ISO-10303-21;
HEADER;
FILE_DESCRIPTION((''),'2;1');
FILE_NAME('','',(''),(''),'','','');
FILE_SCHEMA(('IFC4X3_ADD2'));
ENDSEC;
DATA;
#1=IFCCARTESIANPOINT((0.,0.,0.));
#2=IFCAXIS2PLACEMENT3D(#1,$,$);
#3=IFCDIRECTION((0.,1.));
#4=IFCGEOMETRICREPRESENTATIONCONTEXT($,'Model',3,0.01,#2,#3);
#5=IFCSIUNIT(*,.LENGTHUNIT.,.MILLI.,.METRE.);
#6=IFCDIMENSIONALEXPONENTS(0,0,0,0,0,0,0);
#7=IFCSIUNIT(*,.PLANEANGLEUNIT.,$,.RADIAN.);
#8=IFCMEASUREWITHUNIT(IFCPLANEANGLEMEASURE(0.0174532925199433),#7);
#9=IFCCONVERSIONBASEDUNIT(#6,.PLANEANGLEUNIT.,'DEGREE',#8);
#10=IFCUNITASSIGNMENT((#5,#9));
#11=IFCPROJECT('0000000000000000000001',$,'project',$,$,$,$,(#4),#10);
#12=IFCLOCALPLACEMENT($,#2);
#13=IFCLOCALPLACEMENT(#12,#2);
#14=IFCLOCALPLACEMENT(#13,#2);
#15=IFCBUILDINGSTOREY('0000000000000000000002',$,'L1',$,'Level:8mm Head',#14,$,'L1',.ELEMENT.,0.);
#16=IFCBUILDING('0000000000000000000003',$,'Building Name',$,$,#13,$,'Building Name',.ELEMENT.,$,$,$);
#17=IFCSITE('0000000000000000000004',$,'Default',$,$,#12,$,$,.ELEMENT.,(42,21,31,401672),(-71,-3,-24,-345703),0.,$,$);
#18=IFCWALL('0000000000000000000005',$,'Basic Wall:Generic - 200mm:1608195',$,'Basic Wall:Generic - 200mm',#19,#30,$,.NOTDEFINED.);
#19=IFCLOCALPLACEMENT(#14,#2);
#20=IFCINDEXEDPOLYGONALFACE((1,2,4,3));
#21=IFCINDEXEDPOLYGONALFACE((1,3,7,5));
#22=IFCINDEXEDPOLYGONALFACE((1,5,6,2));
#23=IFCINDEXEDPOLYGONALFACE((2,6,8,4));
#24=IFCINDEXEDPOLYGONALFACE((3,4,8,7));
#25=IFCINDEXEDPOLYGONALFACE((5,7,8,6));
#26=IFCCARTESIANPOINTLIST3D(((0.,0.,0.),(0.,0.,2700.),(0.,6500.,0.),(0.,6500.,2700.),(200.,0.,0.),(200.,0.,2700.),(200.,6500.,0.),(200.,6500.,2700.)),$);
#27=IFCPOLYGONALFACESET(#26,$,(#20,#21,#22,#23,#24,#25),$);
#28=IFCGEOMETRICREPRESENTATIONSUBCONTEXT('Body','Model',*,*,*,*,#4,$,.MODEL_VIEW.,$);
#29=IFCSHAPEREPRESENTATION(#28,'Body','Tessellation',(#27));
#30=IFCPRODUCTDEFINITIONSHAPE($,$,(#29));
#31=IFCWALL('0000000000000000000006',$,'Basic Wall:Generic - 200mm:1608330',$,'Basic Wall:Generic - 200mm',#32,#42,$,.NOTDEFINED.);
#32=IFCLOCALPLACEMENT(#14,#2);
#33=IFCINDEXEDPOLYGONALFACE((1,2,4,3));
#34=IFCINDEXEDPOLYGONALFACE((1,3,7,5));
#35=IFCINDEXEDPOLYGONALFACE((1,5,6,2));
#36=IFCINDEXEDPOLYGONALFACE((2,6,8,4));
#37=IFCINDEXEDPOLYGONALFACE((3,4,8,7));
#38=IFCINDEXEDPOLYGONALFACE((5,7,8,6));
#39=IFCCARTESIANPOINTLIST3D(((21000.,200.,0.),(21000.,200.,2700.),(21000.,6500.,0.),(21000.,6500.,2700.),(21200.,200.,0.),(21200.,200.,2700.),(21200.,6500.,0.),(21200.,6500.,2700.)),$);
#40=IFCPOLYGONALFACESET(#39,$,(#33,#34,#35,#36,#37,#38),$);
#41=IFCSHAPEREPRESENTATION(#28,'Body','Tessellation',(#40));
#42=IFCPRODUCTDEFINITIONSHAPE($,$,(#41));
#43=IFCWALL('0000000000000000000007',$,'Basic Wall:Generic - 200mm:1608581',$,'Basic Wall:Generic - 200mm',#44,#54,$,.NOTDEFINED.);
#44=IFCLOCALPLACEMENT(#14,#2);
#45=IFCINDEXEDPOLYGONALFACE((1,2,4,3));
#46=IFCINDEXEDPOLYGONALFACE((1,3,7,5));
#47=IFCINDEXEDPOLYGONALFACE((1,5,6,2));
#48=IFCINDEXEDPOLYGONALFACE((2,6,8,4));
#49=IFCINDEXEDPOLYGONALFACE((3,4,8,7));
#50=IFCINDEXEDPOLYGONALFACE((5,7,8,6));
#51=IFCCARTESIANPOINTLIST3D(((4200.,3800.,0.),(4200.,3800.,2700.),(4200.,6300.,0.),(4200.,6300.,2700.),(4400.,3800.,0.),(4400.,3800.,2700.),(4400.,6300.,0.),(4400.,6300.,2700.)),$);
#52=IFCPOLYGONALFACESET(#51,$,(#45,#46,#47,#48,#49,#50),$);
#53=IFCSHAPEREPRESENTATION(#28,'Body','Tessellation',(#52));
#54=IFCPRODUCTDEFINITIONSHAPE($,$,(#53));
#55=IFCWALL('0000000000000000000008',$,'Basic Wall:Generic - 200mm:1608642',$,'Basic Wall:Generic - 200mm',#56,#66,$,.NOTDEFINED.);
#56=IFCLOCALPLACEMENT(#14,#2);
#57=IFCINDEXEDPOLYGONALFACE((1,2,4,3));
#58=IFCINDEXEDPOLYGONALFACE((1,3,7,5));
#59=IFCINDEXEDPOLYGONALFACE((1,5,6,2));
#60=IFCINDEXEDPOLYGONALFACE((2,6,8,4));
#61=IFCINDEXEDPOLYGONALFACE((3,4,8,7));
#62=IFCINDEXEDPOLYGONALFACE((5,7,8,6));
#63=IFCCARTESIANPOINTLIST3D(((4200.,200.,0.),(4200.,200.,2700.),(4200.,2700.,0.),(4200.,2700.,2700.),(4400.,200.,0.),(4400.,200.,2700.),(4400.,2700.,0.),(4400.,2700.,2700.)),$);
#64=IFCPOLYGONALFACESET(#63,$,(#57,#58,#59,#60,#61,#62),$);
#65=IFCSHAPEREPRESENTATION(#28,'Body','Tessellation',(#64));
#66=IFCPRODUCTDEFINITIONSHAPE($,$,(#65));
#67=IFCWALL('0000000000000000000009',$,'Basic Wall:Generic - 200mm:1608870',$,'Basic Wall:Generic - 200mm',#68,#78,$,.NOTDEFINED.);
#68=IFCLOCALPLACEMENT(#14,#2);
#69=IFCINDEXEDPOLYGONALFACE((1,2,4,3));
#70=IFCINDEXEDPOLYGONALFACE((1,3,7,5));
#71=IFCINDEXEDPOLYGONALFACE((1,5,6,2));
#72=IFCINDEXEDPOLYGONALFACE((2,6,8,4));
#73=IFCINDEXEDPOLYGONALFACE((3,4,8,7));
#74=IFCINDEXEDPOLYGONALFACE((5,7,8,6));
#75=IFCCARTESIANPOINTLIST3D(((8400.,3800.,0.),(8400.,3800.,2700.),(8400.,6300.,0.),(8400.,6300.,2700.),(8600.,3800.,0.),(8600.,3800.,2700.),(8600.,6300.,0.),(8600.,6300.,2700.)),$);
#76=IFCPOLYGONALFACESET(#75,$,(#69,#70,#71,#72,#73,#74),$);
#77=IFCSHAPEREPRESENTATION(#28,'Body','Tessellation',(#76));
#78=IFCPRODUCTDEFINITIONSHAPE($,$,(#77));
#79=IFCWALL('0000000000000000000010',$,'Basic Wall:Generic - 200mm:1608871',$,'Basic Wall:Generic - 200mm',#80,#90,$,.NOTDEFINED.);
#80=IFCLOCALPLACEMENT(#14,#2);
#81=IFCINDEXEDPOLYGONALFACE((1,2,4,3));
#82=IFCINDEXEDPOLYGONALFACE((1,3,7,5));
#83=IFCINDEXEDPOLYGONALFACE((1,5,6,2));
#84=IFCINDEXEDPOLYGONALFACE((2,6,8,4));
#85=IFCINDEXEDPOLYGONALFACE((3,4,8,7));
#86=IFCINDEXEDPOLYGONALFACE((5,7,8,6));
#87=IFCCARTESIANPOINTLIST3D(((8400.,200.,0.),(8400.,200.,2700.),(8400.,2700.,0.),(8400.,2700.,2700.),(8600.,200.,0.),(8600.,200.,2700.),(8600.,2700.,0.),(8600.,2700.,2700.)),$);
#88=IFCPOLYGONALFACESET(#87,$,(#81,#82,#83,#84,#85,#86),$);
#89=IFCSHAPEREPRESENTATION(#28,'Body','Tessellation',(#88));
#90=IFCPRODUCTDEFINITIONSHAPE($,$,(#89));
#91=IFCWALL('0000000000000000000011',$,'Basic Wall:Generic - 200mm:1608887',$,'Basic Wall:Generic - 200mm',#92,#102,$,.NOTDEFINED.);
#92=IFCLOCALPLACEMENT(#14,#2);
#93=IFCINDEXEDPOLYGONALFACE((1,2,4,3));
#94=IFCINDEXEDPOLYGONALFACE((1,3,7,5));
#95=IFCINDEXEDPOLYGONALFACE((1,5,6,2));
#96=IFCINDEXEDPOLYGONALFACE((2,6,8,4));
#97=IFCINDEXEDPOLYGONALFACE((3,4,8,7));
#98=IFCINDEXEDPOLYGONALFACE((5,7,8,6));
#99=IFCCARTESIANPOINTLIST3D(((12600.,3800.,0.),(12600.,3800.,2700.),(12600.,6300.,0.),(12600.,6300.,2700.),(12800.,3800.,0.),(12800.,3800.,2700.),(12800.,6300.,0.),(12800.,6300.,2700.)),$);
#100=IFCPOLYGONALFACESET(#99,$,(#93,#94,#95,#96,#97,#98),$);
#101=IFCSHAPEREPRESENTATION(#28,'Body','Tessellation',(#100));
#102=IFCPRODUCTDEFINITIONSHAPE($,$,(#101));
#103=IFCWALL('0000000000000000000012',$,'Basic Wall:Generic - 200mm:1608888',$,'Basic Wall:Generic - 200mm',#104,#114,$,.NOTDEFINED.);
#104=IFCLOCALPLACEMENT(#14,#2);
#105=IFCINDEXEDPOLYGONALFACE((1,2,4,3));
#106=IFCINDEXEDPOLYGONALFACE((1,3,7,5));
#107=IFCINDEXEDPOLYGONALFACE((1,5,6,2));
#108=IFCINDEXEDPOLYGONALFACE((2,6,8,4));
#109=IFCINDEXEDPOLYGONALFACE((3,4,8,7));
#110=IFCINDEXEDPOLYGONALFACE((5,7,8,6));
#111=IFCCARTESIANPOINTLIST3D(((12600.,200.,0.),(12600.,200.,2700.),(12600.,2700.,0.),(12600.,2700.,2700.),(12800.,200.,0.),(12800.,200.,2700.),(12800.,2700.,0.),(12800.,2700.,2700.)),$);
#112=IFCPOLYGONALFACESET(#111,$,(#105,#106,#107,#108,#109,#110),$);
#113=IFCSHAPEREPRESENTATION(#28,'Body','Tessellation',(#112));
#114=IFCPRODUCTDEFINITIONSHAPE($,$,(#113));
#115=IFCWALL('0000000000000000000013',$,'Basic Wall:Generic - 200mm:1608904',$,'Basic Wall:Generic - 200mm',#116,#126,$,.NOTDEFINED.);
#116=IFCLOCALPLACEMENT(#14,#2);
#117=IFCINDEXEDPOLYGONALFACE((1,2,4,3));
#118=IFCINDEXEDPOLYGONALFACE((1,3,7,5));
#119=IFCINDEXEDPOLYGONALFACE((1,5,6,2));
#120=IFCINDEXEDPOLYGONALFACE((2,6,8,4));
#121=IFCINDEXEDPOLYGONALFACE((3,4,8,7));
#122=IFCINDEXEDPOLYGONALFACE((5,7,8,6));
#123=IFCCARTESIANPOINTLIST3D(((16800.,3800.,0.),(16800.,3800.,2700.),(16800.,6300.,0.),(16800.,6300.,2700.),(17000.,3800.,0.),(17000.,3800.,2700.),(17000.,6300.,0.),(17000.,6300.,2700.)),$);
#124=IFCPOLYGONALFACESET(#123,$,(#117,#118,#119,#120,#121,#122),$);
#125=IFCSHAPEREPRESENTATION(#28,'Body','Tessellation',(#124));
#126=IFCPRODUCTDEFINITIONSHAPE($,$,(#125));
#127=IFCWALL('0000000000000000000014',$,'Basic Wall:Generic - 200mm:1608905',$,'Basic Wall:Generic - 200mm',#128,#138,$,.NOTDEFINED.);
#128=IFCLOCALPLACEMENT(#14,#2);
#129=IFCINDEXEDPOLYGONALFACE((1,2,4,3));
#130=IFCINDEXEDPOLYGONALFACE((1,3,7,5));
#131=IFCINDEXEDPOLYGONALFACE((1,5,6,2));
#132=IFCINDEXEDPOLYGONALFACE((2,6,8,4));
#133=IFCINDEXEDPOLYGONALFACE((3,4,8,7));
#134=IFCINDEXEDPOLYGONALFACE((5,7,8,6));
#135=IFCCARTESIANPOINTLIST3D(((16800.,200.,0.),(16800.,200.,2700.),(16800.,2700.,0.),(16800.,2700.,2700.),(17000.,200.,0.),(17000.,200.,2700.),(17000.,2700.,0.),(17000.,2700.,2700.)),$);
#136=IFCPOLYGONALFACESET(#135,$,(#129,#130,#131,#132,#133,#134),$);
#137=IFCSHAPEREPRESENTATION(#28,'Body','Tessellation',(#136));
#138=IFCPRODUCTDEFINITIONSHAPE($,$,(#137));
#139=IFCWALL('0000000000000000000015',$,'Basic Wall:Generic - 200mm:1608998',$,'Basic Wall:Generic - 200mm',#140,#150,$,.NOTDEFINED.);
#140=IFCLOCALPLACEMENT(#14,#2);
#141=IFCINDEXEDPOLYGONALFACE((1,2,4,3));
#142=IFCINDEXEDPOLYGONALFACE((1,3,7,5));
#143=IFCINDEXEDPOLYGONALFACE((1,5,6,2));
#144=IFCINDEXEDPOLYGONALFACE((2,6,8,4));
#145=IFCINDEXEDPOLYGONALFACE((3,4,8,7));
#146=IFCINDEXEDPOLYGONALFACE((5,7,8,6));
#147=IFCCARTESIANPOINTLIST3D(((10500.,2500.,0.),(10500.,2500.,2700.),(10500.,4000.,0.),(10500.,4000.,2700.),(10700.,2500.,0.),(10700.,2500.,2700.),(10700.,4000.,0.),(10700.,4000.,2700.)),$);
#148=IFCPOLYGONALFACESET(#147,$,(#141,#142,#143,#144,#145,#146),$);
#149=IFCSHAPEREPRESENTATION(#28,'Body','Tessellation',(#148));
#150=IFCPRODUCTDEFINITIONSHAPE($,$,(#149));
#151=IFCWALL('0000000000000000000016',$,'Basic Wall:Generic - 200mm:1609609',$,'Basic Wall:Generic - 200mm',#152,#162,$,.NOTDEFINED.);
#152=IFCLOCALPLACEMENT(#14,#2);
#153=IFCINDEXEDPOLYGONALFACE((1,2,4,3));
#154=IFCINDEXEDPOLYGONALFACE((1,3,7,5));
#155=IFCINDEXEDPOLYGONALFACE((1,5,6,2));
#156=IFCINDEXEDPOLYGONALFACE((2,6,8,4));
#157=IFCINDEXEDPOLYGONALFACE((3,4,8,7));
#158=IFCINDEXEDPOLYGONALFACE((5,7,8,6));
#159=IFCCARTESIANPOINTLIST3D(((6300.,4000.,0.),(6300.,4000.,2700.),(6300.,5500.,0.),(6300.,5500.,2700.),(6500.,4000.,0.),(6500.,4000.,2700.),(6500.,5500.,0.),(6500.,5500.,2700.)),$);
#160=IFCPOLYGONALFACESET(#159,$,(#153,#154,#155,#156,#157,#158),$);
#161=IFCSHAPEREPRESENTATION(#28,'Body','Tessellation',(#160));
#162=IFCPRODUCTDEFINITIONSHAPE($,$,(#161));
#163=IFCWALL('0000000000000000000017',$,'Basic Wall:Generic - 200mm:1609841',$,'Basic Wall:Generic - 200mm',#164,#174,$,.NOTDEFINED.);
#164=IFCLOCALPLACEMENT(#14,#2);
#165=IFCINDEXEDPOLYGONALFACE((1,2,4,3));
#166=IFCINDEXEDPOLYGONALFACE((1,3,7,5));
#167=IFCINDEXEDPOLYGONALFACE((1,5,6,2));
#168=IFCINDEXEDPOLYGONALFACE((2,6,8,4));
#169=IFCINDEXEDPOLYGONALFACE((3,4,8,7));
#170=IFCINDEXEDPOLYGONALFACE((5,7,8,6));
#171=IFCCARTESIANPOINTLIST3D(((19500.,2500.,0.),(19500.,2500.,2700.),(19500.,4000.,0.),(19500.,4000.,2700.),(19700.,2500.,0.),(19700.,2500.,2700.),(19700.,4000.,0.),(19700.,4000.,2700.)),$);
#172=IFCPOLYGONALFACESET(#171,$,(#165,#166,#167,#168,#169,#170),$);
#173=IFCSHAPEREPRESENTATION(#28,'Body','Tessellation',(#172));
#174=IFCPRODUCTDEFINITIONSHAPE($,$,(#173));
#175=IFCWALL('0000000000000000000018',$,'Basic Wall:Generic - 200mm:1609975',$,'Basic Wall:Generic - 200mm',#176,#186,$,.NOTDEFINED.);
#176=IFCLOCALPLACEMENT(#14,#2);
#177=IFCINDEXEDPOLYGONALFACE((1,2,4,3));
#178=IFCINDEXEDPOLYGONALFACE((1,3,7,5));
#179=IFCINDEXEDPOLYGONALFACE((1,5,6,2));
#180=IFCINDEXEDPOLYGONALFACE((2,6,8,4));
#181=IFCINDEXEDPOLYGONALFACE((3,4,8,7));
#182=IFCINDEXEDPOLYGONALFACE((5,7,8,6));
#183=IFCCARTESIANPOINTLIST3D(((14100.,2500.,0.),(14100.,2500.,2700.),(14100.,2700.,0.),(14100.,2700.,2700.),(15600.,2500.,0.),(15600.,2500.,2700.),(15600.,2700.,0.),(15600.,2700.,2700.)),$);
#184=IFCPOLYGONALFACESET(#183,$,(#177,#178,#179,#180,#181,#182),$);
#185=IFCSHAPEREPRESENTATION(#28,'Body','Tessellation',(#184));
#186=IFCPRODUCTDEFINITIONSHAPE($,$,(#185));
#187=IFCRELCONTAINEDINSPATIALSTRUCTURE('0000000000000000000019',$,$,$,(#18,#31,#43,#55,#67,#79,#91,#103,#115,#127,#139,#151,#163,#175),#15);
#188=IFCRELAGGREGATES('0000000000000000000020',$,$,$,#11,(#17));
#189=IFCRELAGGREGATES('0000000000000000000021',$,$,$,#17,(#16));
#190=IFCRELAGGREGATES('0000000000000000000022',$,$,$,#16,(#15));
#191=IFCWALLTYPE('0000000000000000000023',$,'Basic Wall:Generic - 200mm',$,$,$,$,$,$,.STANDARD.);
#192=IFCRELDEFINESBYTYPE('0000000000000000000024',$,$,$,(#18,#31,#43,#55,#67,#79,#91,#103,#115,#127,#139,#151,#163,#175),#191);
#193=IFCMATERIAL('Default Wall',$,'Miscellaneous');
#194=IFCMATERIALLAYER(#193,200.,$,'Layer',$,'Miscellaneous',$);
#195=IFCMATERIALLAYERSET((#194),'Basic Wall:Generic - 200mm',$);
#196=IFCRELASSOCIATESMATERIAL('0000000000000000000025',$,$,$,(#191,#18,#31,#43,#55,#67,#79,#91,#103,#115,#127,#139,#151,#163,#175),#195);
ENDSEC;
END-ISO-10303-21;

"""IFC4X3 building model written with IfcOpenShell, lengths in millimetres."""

from ifc_helpers import new_model, entity, si_unit, converted_unit, direction, frame, frame_2d, origin, place, context, subcontext, project, spatial, polyline, rectangle, extrude, clip, bounded_halfspace, material, layer, layer_set, type_object, element, save


model = new_model("IFC4X3")

# Units and contexts
model_context = context("Model", 3, precision=0.01, world=origin(), true_north=direction((0.0, 1.0)))
body_context = subcontext(model_context, "Body", "Model", "MODEL_VIEW")
ifc_project = project(units=[si_unit("LENGTHUNIT", "METRE", prefix="MILLI"), converted_unit("PLANEANGLEUNIT", "DEGREE", entity("IfcPlaneAngleMeasure", 0.0174532925199433), si_unit("PLANEANGLEUNIT", "RADIAN"), dimensions=[0, 0, 0, 0, 0, 0, 0])], contexts=[model_context])

# Site, building, storey
site_placement = place(None, origin())
site = spatial("IfcSite", under=ifc_project, at=site_placement, Name="Default", CompositionType="ELEMENT", RefLatitude=(42, 21, 31, 401672), RefLongitude=(-71, -3, -24, -345703), RefElevation=0.0)
building_placement = place(site_placement, origin())
building = spatial("IfcBuilding", under=site, at=building_placement, Name="Building Name", LongName="Building Name", CompositionType="ELEMENT")
storey_placement = place(building_placement, origin())
storey = spatial("IfcBuildingStorey", under=building, at=storey_placement, Name="L1", ObjectType="Level:8mm Head", LongName="L1", CompositionType="ELEMENT", Elevation=0.0)

# Walls
ifc_material = material(Name="Default Wall", Category="Miscellaneous")
ifc_layer = layer(ifc_material, 200.0, Name="Layer", Category="Miscellaneous")
ifc_layer_set = layer_set([ifc_layer], Name="Basic Wall:Generic - 200mm")
wall_type = type_object("IfcWallType", Name="Basic Wall:Generic - 200mm", PredefinedType="STANDARD", material=ifc_layer_set)
wall_1_placement = place(storey_placement, frame((100.0, 6500.0, 0.0), z_axis=(0.0, 0.0, 1.0), x_axis=(0.0, -1.0, 0.0)))
element("IfcWall", 1, at=wall_1_placement, inside=storey, type_object=wall_type, material=ifc_layer_set, Name="Basic Wall:Generic - 200mm:1608195", ObjectType="Basic Wall:Generic - 200mm", PredefinedType="NOTDEFINED", context=body_context, shape_type="Clipping", body=[
    clip(extrude(rectangle(XDim=6500.0, YDim=200.0, at=frame_2d((3250.0, 0.0), x_axis=(-1.0, 0.0))), origin(), (0.0, 0.0, 1.0), 2700.0), bounded_halfspace(frame((0.0, -100.0, 2700.0), z_axis=(0.0, 0.0, -1.0), x_axis=(0.0, -1.0, 0.0)), True, frame((0.0, -100.0, 2700.0)), polyline([(0.0, 0.0), (6500.0, 0.0), (6500.0, 200.0), (6300.0, 200.0), (200.0, 200.0), (0.0, 200.0), (0.0, 0.0)]))),
])
wall_2_placement = place(storey_placement, frame((21100.0, 200.0, 0.0), z_axis=(0.0, 0.0, 1.0), x_axis=(0.0, 1.0, 0.0)))
element("IfcWall", 2, at=wall_2_placement, inside=storey, type_object=wall_type, material=ifc_layer_set, Name="Basic Wall:Generic - 200mm:1608330", ObjectType="Basic Wall:Generic - 200mm", PredefinedType="NOTDEFINED", context=body_context, shape_type="Clipping", body=[
    clip(extrude(rectangle(XDim=6300.0, YDim=200.0, at=frame_2d((3150.0, 0.0), x_axis=(-1.0, 0.0))), origin(), (0.0, 0.0, 1.0), 2700.0), bounded_halfspace(frame((0.0, -100.0, 2700.0), z_axis=(0.0, 0.0, -1.0), x_axis=(0.0, 1.0, 0.0)), True, frame((0.0, -100.0, 2700.0)), polyline([(0.0, 0.0), (6300.0, 0.0), (6300.0, 200.0), (6100.0, 200.0), (0.0, 200.0), (0.0, 0.0)]))),
])
for number, where, z_axis, x_axis, name in (
    (3, (4300.0, 6300.0, 0.0), (0.0, 0.0, 1.0), (0.0, -1.0, 0.0), "Basic Wall:Generic - 200mm:1608581"),
    (4, (4300.0, 2700.0, 0.0), (0.0, 0.0, 1.0), (0.0, -1.0, 0.0), "Basic Wall:Generic - 200mm:1608642"),
    (5, (8500.0, 6300.0, 0.0), (0.0, 0.0, 1.0), (0.0, -1.0, 0.0), "Basic Wall:Generic - 200mm:1608870"),
    (6, (8500.0, 2700.0, 0.0), (0.0, 0.0, 1.0), (0.0, -1.0, 0.0), "Basic Wall:Generic - 200mm:1608871"),
):
    element("IfcWall", number, at=place(storey_placement, frame(where, z_axis=z_axis, x_axis=x_axis)), inside=storey, type_object=wall_type, material=ifc_layer_set, Name=name, ObjectType="Basic Wall:Generic - 200mm", PredefinedType="NOTDEFINED", context=body_context, shape_type="Clipping", body=[
        clip(extrude(rectangle(XDim=2500.0, YDim=200.0, at=frame_2d((1250.0, 0.0), x_axis=(-1.0, 0.0))), origin(), (0.0, 0.0, 1.0), 2700.0), bounded_halfspace(frame((0.0, -100.0, 2700.0), z_axis=(0.0, 0.0, -1.0), x_axis=(0.0, -1.0, 0.0)), True, frame((0.0, -100.0, 2700.0)), polyline([(0.0, 0.0), (2500.0, 0.0), (2500.0, 200.0), (0.0, 200.0), (0.0, 0.0)]))),
    ])
for number, where, z_axis, x_axis, name in (
    (7, (12700.0, 6300.0, 0.0), (0.0, 0.0, 1.0), (0.0, -1.0, 0.0), "Basic Wall:Generic - 200mm:1608887"),
    (8, (12700.0, 2700.0, 0.0), (0.0, 0.0, 1.0), (0.0, -1.0, 0.0), "Basic Wall:Generic - 200mm:1608888"),
):
    element("IfcWall", number, at=place(storey_placement, frame(where, z_axis=z_axis, x_axis=x_axis)), inside=storey, type_object=wall_type, material=ifc_layer_set, Name=name, ObjectType="Basic Wall:Generic - 200mm", PredefinedType="NOTDEFINED", context=body_context, shape_type="Clipping", body=[
        clip(extrude(rectangle(XDim=2500.0, YDim=200.0, at=frame_2d((1250.0, 0.0), x_axis=(-1.0, 0.0))), origin(), (0.0, 0.0, 1.0), 2700.0), bounded_halfspace(frame((0.0, -100.0, 2700.0), z_axis=(0.0, 0.0, -1.0), x_axis=(0.0, -1.0, 0.0)), True, frame((0.0, -100.0, 2700.0)), polyline([(0.0, 0.0), (2500.0, 0.0), (2500.0, 200.0), (0.0, 200.0), (0.0, 0.0)]))),
    ])
for number, where, z_axis, x_axis, name in (
    (9, (16900.0, 6300.0, 0.0), (0.0, 0.0, 1.0), (0.0, -1.0, 0.0), "Basic Wall:Generic - 200mm:1608904"),
    (10, (16900.0, 2700.0, 0.0), (0.0, 0.0, 1.0), (0.0, -1.0, 0.0), "Basic Wall:Generic - 200mm:1608905"),
):
    element("IfcWall", number, at=place(storey_placement, frame(where, z_axis=z_axis, x_axis=x_axis)), inside=storey, type_object=wall_type, material=ifc_layer_set, Name=name, ObjectType="Basic Wall:Generic - 200mm", PredefinedType="NOTDEFINED", context=body_context, shape_type="Clipping", body=[
        clip(extrude(rectangle(XDim=2500.0, YDim=200.0, at=frame_2d((1250.0, 0.0), x_axis=(-1.0, 0.0))), origin(), (0.0, 0.0, 1.0), 2700.0), bounded_halfspace(frame((0.0, -100.0, 2700.0), z_axis=(0.0, 0.0, -1.0), x_axis=(0.0, -1.0, 0.0)), True, frame((0.0, -100.0, 2700.0)), polyline([(0.0, 0.0), (2500.0, 0.0), (2500.0, 200.0), (0.0, 200.0), (0.0, 0.0)]))),
    ])
wall_3_placement = place(storey_placement, frame((10600.0, 4000.0, 0.0), z_axis=(0.0, 0.0, 1.0), x_axis=(0.0, -1.0, 0.0)))
element("IfcWall", 11, at=wall_3_placement, inside=storey, type_object=wall_type, material=ifc_layer_set, Name="Basic Wall:Generic - 200mm:1608998", ObjectType="Basic Wall:Generic - 200mm", PredefinedType="NOTDEFINED", context=body_context, shape_type="Clipping", body=[
    clip(extrude(rectangle(XDim=1500.0, YDim=200.0, at=frame_2d((750.0, 0.0), x_axis=(-1.0, 0.0))), origin(), (0.0, 0.0, 1.0), 2700.0), bounded_halfspace(frame((0.0, -100.0, 2700.0), z_axis=(0.0, 0.0, -1.0), x_axis=(0.0, -1.0, 0.0)), True, frame((0.0, -100.0, 2700.0)), polyline([(0.0, 0.0), (1500.0, 0.0), (1500.0, 200.0), (0.0, 200.0), (0.0, 0.0)]))),
])
wall_4_placement = place(storey_placement, frame((6400.0, 4000.0, 0.0), z_axis=(0.0, 0.0, 1.0), x_axis=(0.0, 1.0, 0.0)))
element("IfcWall", 12, at=wall_4_placement, inside=storey, type_object=wall_type, material=ifc_layer_set, Name="Basic Wall:Generic - 200mm:1609609", ObjectType="Basic Wall:Generic - 200mm", PredefinedType="NOTDEFINED", context=body_context, shape_type="Clipping", body=[
    clip(extrude(rectangle(XDim=1500.0, YDim=200.0, at=frame_2d((750.0, 0.0), x_axis=(-1.0, 0.0))), origin(), (0.0, 0.0, 1.0), 2700.0), bounded_halfspace(frame((0.0, -100.0, 2700.0), z_axis=(0.0, 0.0, -1.0), x_axis=(0.0, 1.0, 0.0)), True, frame((0.0, -100.0, 2700.0)), polyline([(0.0, 0.0), (1500.0, 0.0), (1500.0, 200.0), (0.0, 200.0), (0.0, 0.0)]))),
])
wall_5_placement = place(storey_placement, frame((19600.0, 2500.0, 0.0), z_axis=(0.0, 0.0, 1.0), x_axis=(0.0, 1.0, 0.0)))
element("IfcWall", 13, at=wall_5_placement, inside=storey, type_object=wall_type, material=ifc_layer_set, Name="Basic Wall:Generic - 200mm:1609841", ObjectType="Basic Wall:Generic - 200mm", PredefinedType="NOTDEFINED", context=body_context, shape_type="Clipping", body=[
    clip(extrude(rectangle(XDim=1500.0, YDim=200.0, at=frame_2d((750.0, 0.0), x_axis=(-1.0, 0.0))), origin(), (0.0, 0.0, 1.0), 2700.0), bounded_halfspace(frame((0.0, -100.0, 2700.0), z_axis=(0.0, 0.0, -1.0), x_axis=(0.0, 1.0, 0.0)), True, frame((0.0, -100.0, 2700.0)), polyline([(0.0, 0.0), (1500.0, 0.0), (1500.0, 200.0), (0.0, 200.0), (0.0, 0.0)]))),
])
wall_6_placement = place(storey_placement, frame((14100.0, 2600.0, 0.0)))
element("IfcWall", 14, at=wall_6_placement, inside=storey, type_object=wall_type, material=ifc_layer_set, Name="Basic Wall:Generic - 200mm:1609975", ObjectType="Basic Wall:Generic - 200mm", PredefinedType="NOTDEFINED", context=body_context, shape_type="Clipping", body=[
    clip(extrude(rectangle(XDim=1500.0, YDim=200.0, at=frame_2d((750.0, 0.0), x_axis=(-1.0, 0.0))), origin(), (0.0, 0.0, 1.0), 2700.0), bounded_halfspace(frame((0.0, -100.0, 2700.0), z_axis=(0.0, 0.0, -1.0), x_axis=(-1.0, 0.0, 0.0)), True, frame((0.0, -100.0, 2700.0)), polyline([(0.0, 0.0), (1500.0, 0.0), (1500.0, 200.0), (0.0, 200.0), (0.0, 0.0)]))),
])

save(model, "model.ifc")
